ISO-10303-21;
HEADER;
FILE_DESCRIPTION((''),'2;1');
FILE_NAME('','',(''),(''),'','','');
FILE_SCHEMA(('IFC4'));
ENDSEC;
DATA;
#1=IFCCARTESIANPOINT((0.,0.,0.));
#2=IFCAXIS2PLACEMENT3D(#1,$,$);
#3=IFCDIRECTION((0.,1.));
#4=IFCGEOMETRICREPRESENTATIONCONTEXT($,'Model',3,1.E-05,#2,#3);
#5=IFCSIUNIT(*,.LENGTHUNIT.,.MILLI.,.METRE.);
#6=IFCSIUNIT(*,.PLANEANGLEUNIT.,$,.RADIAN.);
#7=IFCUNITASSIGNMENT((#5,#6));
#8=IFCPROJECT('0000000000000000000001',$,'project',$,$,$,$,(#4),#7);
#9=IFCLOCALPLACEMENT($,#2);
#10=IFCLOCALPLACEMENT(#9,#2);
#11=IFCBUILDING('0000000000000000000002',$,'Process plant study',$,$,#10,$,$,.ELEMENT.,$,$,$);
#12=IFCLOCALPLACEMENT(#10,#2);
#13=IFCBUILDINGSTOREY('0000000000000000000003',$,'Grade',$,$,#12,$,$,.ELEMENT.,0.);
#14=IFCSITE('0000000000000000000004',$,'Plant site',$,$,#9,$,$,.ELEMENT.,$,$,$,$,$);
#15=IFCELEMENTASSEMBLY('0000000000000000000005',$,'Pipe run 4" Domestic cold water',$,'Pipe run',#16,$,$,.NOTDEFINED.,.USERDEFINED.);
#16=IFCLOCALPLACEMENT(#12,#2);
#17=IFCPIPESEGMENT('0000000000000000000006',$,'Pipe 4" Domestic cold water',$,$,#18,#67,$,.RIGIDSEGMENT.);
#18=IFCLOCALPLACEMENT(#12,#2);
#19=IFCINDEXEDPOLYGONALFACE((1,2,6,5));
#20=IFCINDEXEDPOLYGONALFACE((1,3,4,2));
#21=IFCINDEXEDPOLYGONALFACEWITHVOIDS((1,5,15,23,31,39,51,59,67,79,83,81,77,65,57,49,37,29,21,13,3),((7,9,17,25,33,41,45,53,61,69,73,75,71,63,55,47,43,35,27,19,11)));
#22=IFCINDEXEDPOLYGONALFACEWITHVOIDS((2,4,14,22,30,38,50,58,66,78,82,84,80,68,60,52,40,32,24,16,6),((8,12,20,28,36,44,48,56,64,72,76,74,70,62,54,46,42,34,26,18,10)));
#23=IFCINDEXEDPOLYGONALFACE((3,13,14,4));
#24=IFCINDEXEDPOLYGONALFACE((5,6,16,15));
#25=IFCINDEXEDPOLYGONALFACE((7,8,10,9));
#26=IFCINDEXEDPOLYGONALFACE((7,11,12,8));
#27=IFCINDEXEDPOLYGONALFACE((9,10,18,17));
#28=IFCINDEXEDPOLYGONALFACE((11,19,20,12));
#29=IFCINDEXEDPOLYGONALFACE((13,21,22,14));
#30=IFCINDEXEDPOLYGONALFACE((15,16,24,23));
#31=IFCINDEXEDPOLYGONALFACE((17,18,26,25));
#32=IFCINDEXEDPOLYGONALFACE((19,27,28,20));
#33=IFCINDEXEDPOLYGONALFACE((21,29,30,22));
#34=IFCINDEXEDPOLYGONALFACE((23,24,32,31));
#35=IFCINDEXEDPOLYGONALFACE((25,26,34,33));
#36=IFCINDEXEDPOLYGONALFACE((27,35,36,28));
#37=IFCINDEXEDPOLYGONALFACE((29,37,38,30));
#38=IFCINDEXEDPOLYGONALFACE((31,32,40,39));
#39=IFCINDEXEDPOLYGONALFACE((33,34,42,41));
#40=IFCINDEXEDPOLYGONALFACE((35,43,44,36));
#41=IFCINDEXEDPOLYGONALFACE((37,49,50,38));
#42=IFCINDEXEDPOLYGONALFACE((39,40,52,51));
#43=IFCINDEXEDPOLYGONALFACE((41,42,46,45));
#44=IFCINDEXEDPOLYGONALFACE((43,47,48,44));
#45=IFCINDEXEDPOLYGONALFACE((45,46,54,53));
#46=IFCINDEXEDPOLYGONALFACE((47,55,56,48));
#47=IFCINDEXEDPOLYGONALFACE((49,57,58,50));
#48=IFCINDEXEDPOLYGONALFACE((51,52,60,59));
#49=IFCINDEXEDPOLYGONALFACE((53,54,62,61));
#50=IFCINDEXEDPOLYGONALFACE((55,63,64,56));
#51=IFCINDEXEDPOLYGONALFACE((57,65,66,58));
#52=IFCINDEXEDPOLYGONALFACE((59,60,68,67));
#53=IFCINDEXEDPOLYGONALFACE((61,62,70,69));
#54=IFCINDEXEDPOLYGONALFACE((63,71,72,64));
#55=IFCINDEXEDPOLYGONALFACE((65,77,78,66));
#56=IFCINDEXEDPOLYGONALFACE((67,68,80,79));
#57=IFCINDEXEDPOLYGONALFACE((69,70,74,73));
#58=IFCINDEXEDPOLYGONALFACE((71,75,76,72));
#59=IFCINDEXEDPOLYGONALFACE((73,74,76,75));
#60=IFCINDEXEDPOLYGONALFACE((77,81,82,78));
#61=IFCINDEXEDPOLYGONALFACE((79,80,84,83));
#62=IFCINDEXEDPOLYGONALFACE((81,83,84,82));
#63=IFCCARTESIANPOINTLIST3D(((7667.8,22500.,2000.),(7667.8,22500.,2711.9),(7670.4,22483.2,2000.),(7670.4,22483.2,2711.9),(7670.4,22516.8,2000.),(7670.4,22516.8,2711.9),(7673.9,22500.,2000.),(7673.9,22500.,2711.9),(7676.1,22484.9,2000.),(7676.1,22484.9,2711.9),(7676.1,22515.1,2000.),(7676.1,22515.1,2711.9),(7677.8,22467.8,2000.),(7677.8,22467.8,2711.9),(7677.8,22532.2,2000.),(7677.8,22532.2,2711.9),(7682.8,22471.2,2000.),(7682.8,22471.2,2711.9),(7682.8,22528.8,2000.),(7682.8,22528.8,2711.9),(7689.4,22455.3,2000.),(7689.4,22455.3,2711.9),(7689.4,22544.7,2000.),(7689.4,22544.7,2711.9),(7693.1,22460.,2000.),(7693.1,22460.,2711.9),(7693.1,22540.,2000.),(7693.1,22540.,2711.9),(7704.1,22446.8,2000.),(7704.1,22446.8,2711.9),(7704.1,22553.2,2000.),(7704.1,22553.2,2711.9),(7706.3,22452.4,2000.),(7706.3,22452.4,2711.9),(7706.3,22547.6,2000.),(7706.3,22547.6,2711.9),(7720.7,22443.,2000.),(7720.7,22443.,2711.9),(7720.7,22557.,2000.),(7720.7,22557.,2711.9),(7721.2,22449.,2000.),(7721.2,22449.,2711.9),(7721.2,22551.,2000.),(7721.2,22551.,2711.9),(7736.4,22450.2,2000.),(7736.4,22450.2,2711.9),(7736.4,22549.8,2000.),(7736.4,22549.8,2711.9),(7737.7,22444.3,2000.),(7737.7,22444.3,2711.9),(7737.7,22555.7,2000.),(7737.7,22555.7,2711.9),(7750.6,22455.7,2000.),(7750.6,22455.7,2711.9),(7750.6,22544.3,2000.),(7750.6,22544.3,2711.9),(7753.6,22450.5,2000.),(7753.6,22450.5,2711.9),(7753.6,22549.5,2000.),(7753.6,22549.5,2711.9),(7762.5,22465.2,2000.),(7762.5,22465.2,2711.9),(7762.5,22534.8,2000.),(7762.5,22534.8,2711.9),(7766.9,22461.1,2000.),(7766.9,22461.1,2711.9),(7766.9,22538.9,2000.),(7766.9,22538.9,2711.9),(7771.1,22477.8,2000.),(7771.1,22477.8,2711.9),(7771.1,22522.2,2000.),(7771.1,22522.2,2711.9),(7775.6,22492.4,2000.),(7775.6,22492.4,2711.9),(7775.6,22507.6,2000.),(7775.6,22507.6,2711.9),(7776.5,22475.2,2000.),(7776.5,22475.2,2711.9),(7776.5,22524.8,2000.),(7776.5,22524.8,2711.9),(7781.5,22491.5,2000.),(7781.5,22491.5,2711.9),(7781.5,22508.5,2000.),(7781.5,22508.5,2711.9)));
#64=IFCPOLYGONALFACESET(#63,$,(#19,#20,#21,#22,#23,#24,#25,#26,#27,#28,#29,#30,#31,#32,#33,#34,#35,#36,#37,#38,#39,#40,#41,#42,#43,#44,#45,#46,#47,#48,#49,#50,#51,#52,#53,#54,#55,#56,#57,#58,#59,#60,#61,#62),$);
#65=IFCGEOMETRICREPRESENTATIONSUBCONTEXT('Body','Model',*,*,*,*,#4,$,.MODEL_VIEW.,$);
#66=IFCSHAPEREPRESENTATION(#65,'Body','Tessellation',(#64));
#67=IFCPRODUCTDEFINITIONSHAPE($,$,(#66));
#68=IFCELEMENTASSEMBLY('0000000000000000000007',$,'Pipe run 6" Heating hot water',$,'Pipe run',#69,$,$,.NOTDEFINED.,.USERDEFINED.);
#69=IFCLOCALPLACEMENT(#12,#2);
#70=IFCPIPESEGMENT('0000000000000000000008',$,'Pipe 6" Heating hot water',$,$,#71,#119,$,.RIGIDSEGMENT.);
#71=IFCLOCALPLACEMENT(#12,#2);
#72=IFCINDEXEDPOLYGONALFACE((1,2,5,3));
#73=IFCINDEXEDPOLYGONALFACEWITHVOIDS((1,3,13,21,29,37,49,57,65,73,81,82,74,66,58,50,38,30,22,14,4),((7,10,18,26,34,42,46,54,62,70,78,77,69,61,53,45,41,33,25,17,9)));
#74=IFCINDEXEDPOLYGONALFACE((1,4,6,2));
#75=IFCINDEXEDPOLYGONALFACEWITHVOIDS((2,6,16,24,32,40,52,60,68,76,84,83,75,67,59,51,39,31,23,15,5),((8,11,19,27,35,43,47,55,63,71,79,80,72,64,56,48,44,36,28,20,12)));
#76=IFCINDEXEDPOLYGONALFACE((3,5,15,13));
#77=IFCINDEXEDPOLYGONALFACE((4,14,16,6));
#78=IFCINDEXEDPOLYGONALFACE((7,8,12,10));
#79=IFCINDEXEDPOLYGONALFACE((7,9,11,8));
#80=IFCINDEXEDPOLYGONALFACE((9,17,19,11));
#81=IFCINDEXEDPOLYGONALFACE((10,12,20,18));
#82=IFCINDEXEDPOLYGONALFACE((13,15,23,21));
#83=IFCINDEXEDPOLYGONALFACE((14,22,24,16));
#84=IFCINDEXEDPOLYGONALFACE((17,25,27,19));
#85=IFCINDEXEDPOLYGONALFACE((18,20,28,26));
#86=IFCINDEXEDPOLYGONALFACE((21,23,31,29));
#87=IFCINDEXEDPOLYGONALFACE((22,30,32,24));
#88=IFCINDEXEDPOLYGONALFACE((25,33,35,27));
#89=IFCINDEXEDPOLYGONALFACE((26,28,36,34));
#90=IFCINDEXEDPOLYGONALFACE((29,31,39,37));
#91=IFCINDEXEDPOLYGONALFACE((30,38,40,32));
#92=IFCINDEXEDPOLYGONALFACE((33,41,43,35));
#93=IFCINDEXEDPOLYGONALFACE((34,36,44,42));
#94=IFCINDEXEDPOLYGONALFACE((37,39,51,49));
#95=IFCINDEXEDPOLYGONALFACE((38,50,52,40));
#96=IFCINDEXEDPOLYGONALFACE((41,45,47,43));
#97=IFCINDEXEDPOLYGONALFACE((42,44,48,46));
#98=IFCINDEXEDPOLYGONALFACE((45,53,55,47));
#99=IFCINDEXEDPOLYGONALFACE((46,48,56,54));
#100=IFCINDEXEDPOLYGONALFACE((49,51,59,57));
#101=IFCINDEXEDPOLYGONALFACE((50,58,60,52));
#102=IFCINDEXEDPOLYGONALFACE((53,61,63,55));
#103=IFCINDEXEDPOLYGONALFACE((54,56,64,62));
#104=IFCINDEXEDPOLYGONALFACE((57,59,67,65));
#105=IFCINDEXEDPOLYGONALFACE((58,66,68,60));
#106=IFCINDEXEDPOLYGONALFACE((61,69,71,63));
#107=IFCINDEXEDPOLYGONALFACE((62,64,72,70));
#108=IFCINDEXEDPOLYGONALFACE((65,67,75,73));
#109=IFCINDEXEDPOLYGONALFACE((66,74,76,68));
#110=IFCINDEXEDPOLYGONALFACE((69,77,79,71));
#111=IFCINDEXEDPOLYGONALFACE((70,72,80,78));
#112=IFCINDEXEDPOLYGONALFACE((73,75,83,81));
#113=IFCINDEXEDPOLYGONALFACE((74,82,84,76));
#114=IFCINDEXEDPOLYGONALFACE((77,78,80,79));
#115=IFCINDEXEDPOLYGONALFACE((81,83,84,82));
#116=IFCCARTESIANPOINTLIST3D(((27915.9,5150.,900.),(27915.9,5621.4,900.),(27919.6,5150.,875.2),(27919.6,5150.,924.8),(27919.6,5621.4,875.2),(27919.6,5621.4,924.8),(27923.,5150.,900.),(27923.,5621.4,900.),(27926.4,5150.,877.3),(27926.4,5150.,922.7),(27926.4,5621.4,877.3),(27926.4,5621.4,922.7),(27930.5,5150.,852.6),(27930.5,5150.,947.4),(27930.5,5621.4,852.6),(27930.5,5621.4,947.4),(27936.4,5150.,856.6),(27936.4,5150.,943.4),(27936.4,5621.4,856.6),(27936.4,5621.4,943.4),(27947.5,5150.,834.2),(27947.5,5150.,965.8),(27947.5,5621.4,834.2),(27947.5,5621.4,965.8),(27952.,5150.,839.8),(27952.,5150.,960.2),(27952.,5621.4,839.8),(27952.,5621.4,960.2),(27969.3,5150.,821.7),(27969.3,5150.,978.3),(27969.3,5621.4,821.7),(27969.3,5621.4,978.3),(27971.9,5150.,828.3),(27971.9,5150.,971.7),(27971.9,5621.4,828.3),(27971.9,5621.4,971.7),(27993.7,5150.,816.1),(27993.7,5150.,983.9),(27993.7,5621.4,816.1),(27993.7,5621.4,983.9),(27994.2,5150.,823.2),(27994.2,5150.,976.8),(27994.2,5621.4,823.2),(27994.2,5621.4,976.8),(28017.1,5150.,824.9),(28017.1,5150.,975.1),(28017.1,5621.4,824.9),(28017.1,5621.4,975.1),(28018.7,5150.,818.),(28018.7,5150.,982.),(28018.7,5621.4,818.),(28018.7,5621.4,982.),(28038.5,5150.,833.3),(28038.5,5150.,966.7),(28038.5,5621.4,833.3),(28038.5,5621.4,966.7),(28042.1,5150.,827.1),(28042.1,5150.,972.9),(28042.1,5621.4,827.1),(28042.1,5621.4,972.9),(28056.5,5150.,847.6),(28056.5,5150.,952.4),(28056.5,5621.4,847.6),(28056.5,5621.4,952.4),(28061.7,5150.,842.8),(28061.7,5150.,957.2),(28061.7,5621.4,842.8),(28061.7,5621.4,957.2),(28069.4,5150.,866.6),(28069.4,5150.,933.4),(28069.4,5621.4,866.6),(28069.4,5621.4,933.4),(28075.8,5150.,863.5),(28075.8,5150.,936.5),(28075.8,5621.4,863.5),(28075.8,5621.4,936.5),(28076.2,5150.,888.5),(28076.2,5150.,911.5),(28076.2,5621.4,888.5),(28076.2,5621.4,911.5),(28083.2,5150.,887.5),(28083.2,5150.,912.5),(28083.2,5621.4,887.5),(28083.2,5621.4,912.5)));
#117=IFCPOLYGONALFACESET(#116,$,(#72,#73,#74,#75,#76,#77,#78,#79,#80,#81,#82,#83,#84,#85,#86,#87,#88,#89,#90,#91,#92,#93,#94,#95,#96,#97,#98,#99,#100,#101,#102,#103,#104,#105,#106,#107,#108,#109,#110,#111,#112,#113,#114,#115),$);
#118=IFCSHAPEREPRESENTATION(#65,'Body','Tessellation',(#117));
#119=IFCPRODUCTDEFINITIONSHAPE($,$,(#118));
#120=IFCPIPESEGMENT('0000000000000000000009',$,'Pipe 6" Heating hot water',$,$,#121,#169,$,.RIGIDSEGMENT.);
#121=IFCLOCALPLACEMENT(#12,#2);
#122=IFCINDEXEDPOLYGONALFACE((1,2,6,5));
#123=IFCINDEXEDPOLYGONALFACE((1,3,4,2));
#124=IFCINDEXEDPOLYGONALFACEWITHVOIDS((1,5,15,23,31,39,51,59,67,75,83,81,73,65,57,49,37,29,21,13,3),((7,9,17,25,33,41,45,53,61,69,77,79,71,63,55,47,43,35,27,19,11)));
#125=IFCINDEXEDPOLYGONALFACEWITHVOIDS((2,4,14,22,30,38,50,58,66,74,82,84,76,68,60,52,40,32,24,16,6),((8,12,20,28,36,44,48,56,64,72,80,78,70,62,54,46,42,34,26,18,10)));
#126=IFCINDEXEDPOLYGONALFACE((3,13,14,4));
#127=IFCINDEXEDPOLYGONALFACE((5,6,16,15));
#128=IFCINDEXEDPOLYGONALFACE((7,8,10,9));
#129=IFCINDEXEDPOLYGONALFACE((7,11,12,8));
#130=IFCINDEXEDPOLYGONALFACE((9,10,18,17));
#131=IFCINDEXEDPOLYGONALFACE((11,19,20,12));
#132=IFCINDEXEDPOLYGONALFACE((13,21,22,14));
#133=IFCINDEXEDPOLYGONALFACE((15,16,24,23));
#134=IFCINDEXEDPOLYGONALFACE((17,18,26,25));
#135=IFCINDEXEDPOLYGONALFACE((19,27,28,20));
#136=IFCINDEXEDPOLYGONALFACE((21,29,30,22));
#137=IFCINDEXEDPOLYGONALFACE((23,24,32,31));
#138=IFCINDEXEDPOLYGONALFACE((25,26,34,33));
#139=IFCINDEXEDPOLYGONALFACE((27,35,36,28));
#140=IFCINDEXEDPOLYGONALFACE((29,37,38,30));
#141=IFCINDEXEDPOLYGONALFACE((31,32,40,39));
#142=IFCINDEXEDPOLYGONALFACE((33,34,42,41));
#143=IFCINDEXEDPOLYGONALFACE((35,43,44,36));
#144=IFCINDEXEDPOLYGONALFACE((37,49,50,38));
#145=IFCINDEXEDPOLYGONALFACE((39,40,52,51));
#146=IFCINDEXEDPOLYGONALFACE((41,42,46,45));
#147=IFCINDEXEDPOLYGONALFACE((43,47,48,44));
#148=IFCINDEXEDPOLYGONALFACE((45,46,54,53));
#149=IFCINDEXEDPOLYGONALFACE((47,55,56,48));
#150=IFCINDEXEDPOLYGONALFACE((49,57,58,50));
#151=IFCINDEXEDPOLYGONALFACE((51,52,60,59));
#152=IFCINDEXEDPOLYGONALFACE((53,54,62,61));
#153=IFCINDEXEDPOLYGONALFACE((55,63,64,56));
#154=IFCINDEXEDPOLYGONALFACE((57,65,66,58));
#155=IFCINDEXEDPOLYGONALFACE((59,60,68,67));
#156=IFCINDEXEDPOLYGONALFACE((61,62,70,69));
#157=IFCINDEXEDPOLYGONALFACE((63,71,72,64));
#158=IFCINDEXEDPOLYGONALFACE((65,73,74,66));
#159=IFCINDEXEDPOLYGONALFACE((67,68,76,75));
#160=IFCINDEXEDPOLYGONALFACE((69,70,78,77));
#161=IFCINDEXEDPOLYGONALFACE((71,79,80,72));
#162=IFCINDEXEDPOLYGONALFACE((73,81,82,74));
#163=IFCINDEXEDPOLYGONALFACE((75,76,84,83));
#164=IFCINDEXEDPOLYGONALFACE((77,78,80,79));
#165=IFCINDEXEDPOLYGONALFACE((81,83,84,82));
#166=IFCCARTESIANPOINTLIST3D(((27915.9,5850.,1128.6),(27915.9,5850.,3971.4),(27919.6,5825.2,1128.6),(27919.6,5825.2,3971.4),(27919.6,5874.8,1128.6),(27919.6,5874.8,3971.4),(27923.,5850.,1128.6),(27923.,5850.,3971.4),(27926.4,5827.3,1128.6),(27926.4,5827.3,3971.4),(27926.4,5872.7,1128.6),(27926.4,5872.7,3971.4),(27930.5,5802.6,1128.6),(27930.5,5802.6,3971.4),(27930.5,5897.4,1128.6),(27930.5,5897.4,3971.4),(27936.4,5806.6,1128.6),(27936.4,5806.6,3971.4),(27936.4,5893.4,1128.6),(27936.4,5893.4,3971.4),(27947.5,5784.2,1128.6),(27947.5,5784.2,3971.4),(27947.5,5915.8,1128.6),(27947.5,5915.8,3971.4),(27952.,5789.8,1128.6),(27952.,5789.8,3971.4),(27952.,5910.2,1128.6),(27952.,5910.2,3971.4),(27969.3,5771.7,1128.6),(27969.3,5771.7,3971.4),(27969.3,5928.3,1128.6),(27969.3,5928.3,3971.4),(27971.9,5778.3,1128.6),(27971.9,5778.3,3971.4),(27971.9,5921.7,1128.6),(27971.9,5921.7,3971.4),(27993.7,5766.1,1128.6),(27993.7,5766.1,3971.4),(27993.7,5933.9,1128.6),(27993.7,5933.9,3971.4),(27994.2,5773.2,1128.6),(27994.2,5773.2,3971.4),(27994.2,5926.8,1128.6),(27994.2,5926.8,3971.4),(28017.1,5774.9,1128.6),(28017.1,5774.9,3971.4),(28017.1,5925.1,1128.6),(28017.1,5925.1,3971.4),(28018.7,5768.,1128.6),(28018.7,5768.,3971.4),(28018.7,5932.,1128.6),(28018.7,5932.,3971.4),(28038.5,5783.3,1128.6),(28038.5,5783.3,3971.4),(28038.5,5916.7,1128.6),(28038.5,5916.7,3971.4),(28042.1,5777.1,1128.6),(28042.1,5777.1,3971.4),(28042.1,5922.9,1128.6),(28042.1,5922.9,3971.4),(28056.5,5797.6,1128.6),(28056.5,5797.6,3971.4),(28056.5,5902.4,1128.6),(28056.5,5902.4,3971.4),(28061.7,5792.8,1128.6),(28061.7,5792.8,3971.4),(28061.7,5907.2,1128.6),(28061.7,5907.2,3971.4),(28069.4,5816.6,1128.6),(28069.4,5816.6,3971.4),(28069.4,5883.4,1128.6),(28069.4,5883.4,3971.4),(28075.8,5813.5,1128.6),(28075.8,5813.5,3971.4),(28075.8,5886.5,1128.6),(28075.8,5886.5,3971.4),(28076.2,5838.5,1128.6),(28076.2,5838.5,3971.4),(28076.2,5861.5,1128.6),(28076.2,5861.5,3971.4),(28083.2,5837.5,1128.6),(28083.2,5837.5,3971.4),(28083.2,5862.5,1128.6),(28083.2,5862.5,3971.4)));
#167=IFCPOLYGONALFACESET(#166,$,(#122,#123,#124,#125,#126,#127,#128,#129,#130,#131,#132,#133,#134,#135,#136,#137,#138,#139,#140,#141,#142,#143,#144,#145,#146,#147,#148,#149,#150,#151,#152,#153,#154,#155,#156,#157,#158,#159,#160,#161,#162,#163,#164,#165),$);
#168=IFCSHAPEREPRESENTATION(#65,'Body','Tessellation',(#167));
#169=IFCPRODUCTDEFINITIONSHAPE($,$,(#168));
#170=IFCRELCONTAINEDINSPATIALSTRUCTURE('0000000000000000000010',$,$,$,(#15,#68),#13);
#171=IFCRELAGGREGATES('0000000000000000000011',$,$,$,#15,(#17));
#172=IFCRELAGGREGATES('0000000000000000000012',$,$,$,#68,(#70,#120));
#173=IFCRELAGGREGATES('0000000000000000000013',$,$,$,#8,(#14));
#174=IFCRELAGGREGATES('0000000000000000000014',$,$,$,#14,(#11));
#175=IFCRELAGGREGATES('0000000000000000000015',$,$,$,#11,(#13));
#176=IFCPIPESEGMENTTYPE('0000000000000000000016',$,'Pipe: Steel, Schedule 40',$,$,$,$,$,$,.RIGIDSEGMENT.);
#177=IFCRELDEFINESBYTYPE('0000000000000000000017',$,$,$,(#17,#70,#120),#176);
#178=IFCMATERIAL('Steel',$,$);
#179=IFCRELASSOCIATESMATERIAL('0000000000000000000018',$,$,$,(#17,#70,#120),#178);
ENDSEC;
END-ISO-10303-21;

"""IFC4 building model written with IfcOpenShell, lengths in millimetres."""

from ifc_helpers import new_model, si_unit, direction, frame, origin, origin_with_axes, origin_2d, place, context, subcontext, project, spatial, hollow_circle, extrude, material, type_object, element, aggregate, save


model = new_model("IFC4")

# Units and contexts
model_context = context("Model", 3, precision=1e-05, world=origin(), true_north=direction((0.0, 1.0)))
body_context = subcontext(model_context, "Body", "Model", "MODEL_VIEW")
ifc_project = project(units=[si_unit("LENGTHUNIT", "METRE", prefix="MILLI"), si_unit("PLANEANGLEUNIT", "RADIAN")], contexts=[model_context])

# Site, building, storey
site_placement = place(None, origin())
site = spatial("IfcSite", under=ifc_project, at=site_placement, Name="Plant site", CompositionType="ELEMENT")
building_placement = place(site_placement, origin())
building = spatial("IfcBuilding", under=site, at=building_placement, Name="Process plant study", CompositionType="ELEMENT")
storey_placement = place(building_placement, origin())
storey = spatial("IfcBuildingStorey", under=building, at=storey_placement, Name="Grade", CompositionType="ELEMENT", Elevation=0.0)

# Element assemblies, pipe segments
assembly_1_placement = place(storey_placement, origin_with_axes())
assembly_1 = element("IfcElementAssembly", 1, at=assembly_1_placement, inside=storey, Name="Pipe run 4\" Domestic cold water", ObjectType="Pipe run", AssemblyPlace="NOTDEFINED", PredefinedType="USERDEFINED")
ifc_material = material(Name="Steel")
pipe_segment_type = type_object("IfcPipeSegmentType", Name="Pipe: Steel, Schedule 40", PredefinedType="RIGIDSEGMENT")
pipe_segment_1_placement = place(storey_placement, origin_with_axes())
pipe_segment_1 = element("IfcPipeSegment", 2, at=pipe_segment_1_placement, type_object=pipe_segment_type, material=ifc_material, Name="Pipe 4\" Domestic cold water", PredefinedType="RIGIDSEGMENT", context=body_context, shape_type="SweptSolid", body=[
    extrude(hollow_circle(Radius=57.1, WallThickness=6.0, at=origin_2d()), frame((7725.0, 22500.0, 2711.9), z_axis=(0.0, 0.0, -1.0), x_axis=(-1.0, 0.0, 0.0)), (0.0, 0.0, 1.0), 711.9),
])
assembly_2_placement = place(storey_placement, origin_with_axes())
assembly_2 = element("IfcElementAssembly", 3, at=assembly_2_placement, inside=storey, Name="Pipe run 6\" Heating hot water", ObjectType="Pipe run", AssemblyPlace="NOTDEFINED", PredefinedType="USERDEFINED")
pipe_segment_2_placement = place(storey_placement, origin_with_axes())
pipe_segment_2 = element("IfcPipeSegment", 4, at=pipe_segment_2_placement, type_object=pipe_segment_type, material=ifc_material, Name="Pipe 6\" Heating hot water", PredefinedType="RIGIDSEGMENT", context=body_context, shape_type="SweptSolid", body=[
    extrude(hollow_circle(Radius=84.1, WallThickness=7.1, at=origin_2d()), frame((28000.0, 5150.0, 900.0), z_axis=(0.0, 1.0, 0.0), x_axis=(-1.0, 0.0, 0.0)), (0.0, 0.0, 1.0), 471.4),
])
pipe_segment_3_placement = place(storey_placement, origin_with_axes())
pipe_segment_3 = element("IfcPipeSegment", 5, at=pipe_segment_3_placement, type_object=pipe_segment_type, material=ifc_material, Name="Pipe 6\" Heating hot water", PredefinedType="RIGIDSEGMENT", context=body_context, shape_type="SweptSolid", body=[
    extrude(hollow_circle(Radius=84.1, WallThickness=7.1, at=origin_2d()), frame((28000.0, 5850.0, 1128.6), z_axis=(0.0, 0.0, 1.0), x_axis=(-1.0, 0.0, 0.0)), (0.0, 0.0, 1.0), 2842.8),
])

aggregate(assembly_1, [pipe_segment_1])
aggregate(assembly_2, [pipe_segment_2, pipe_segment_3])

save(model, "model.ifc")
